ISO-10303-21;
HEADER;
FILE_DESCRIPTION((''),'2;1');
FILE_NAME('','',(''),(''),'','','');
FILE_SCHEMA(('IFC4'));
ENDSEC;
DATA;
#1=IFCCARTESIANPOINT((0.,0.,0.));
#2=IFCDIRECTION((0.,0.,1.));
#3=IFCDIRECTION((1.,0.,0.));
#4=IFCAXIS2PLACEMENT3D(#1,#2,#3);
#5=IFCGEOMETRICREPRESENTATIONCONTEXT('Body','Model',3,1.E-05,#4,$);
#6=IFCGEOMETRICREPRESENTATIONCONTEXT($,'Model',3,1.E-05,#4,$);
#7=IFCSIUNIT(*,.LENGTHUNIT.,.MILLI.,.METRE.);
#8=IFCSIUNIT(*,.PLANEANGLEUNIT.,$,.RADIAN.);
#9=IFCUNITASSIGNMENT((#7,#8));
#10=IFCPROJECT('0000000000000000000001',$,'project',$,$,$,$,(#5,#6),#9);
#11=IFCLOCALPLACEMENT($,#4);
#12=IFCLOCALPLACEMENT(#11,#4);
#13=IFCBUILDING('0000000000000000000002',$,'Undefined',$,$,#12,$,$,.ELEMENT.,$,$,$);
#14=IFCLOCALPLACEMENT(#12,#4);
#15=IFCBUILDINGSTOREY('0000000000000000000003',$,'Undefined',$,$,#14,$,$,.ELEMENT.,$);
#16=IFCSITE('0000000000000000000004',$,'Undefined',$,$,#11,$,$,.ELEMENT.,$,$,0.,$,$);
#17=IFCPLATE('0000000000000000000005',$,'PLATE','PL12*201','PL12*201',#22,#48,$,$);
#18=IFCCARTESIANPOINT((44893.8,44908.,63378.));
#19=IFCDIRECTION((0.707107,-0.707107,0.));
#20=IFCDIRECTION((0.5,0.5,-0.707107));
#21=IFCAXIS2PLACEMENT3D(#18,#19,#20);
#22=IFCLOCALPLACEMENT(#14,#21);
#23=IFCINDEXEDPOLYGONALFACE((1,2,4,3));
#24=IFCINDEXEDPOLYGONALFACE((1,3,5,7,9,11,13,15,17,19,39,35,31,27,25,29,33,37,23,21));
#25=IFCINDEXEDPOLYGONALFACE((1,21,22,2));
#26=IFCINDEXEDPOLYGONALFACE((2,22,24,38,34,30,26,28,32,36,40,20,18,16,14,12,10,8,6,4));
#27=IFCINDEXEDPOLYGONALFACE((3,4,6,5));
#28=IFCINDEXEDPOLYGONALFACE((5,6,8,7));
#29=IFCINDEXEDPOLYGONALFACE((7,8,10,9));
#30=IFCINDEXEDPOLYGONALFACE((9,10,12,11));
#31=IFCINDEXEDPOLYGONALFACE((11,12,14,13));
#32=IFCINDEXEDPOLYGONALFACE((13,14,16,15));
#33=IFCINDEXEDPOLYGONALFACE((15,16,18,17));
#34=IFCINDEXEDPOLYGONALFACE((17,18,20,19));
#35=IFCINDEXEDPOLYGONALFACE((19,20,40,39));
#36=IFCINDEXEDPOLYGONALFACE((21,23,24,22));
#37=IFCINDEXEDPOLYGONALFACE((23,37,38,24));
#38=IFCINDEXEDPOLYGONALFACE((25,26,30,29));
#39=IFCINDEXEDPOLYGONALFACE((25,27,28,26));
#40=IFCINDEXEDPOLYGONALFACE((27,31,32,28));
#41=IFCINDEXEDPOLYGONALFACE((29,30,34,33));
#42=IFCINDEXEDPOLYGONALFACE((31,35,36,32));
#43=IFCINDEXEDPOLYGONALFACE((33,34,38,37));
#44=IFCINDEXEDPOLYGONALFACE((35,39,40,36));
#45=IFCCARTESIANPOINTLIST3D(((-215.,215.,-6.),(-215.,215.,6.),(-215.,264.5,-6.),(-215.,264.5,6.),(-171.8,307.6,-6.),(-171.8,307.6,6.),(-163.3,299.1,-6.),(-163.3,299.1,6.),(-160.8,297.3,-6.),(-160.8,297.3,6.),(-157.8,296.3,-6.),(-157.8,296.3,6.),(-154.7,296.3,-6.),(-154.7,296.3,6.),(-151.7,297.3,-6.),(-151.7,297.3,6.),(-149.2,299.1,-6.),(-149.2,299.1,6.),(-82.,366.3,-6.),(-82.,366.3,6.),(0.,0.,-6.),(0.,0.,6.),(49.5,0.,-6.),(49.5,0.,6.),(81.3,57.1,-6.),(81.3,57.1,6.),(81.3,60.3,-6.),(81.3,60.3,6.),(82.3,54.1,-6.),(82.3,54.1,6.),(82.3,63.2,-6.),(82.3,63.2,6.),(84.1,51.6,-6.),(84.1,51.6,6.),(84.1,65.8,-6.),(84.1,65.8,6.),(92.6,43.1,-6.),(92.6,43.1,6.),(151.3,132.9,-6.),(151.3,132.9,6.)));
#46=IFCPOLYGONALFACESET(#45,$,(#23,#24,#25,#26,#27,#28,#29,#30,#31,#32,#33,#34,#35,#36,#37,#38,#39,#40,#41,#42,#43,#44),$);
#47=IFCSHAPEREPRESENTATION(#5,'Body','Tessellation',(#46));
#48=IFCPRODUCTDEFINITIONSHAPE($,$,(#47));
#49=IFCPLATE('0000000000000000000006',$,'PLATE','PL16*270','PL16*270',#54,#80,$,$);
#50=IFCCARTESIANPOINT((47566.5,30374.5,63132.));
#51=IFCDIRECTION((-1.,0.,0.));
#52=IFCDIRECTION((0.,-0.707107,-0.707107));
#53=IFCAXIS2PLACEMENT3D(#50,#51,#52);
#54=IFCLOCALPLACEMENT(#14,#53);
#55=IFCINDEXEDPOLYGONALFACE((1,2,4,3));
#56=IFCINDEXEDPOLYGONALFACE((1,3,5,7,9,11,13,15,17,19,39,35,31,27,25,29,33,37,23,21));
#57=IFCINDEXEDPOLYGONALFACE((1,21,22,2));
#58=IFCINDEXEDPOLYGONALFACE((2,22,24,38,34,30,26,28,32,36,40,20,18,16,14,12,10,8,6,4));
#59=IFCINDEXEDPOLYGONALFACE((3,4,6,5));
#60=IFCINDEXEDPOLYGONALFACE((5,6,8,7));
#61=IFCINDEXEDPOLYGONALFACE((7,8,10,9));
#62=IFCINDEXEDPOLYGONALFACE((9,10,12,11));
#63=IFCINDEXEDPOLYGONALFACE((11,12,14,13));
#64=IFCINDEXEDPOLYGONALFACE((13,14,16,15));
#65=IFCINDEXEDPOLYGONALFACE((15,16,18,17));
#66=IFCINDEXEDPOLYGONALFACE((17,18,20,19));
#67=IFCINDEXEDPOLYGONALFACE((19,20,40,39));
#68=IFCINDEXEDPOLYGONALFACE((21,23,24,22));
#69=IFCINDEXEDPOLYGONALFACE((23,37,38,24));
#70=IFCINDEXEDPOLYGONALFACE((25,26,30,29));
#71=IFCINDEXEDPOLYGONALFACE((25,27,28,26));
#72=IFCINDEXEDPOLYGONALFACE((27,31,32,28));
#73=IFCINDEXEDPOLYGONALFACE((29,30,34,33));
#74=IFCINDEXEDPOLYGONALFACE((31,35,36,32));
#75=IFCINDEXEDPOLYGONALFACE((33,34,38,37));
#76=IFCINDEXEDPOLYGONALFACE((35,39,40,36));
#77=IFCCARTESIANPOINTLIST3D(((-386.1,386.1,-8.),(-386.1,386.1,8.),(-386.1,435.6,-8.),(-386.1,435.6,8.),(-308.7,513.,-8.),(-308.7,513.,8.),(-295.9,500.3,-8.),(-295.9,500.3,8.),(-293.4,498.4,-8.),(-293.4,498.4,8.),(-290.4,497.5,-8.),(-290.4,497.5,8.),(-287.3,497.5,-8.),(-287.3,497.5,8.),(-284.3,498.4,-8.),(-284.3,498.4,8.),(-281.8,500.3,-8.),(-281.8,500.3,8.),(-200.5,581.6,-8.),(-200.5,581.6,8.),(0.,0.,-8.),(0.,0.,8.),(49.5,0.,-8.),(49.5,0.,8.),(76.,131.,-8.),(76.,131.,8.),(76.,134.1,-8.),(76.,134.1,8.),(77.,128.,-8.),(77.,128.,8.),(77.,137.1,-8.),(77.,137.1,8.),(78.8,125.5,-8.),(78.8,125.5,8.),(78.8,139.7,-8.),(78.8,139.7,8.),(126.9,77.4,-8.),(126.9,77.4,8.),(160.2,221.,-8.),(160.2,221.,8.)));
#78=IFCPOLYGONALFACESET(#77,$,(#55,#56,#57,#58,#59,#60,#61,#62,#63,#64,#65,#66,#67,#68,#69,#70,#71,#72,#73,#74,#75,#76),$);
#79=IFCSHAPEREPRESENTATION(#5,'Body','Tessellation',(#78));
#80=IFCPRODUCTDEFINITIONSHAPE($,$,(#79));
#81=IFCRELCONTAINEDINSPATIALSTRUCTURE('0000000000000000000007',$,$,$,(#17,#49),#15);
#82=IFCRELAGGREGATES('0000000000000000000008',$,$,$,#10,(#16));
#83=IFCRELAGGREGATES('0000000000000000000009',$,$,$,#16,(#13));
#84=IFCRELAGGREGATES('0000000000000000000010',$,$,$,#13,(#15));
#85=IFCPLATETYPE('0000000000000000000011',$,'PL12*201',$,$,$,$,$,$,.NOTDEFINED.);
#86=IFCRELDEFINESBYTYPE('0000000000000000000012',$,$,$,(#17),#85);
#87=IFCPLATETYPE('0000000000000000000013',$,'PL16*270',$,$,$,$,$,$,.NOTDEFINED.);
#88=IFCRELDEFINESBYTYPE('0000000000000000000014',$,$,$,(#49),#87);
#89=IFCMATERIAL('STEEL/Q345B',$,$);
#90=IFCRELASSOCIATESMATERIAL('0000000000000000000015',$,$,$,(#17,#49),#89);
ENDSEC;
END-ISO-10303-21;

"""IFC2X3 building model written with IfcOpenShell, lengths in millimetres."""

from ifc_helpers import new_model, si_unit, frame, origin_with_axes, place, context, project, spatial, polyline, outline, extrude, material, type_object, element, save


model = new_model("IFC2X3")

# Units and contexts
model_context_1 = context("Model", 3, precision=1e-05, world=origin_with_axes(), identifier="Body")
model_context_2 = context("Model", 3, precision=1e-05, world=origin_with_axes())
ifc_project = project(units=[si_unit("LENGTHUNIT", "METRE", prefix="MILLI"), si_unit("PLANEANGLEUNIT", "RADIAN")], contexts=[model_context_1, model_context_2])

# Site, building, storey
site_placement = place(None, origin_with_axes())
site = spatial("IfcSite", under=ifc_project, at=site_placement, Name="Undefined", CompositionType="ELEMENT", RefElevation=0.0)
building_placement = place(site_placement, origin_with_axes())
building = spatial("IfcBuilding", under=site, at=building_placement, Name="Undefined", CompositionType="ELEMENT")
storey_placement = place(building_placement, origin_with_axes())
storey = spatial("IfcBuildingStorey", under=building, at=storey_placement, Name="Undefined", CompositionType="ELEMENT")

# Shared definitions
ifc_material_1 = material(Name="STEEL/Q345B")

# Plates
plate_type_1 = type_object("IfcPlateType", Name="PL12*201", PredefinedType="NOTDEFINED")
plate_1_placement = place(storey_placement, frame((44893.8, 44908.0, 63378.0), z_axis=(0.707107, -0.707107, 0.0), x_axis=(0.5, 0.5, -0.707107)))
element("IfcPlate", 1, at=plate_1_placement, inside=storey, type_object=plate_type_1, material=ifc_material_1, Name="PLATE", Description="PL12*201", ObjectType="PL12*201", context=model_context_1, shape_type="SweptSolid", body=[
    extrude(outline(polyline([(0.0, 0.0), (49.5, 0.0), (92.6, 43.1), (84.1, 51.6), (82.3, 54.1), (81.3, 57.1), (81.3, 60.3), (82.3, 63.2), (84.1, 65.8), (151.3, 132.9), (-82.0, 366.3), (-149.2, 299.1), (-151.7, 297.3), (-154.7, 296.3), (-157.8, 296.3), (-160.8, 297.3), (-163.3, 299.1), (-171.8, 307.6), (-215.0, 264.5), (-215.0, 215.0), (0.0, 0.0)])), frame((0.0, 0.0, -6.0), z_axis=(0.0, 0.0, 1.0), x_axis=(1.0, 0.0, 0.0)), (0.0, 0.0, 1.0), 12.0),
])
plate_type_2 = type_object("IfcPlateType", Name="PL16*270", PredefinedType="NOTDEFINED")
for number, where, z_axis, x_axis, name in (
    (2, (47566.5, 30374.5, 63132.0), (-1.0, 0.0, 0.0), (0.0, -0.707107, -0.707107), "PLATE"),
):
    element("IfcPlate", number, at=place(storey_placement, frame(where, z_axis=z_axis, x_axis=x_axis)), inside=storey, type_object=plate_type_2, material=ifc_material_1, Name=name, Description="PL16*270", ObjectType="PL16*270", context=model_context_1, shape_type="SweptSolid", body=[
        extrude(outline(polyline([(0.0, 0.0), (49.5, 0.0), (126.9, 77.4), (78.8, 125.5), (77.0, 128.0), (76.0, 131.0), (76.0, 134.1), (77.0, 137.1), (78.8, 139.7), (160.2, 221.0), (-200.5, 581.6), (-281.8, 500.3), (-284.3, 498.4), (-287.3, 497.5), (-290.4, 497.5), (-293.4, 498.4), (-295.9, 500.3), (-308.7, 513.0), (-386.1, 435.6), (-386.1, 386.1), (0.0, 0.0)])), frame((0.0, 0.0, -8.0), z_axis=(0.0, 0.0, 1.0), x_axis=(1.0, 0.0, 0.0)), (0.0, 0.0, 1.0), 16.0),
    ])

save(model, "model.ifc")
